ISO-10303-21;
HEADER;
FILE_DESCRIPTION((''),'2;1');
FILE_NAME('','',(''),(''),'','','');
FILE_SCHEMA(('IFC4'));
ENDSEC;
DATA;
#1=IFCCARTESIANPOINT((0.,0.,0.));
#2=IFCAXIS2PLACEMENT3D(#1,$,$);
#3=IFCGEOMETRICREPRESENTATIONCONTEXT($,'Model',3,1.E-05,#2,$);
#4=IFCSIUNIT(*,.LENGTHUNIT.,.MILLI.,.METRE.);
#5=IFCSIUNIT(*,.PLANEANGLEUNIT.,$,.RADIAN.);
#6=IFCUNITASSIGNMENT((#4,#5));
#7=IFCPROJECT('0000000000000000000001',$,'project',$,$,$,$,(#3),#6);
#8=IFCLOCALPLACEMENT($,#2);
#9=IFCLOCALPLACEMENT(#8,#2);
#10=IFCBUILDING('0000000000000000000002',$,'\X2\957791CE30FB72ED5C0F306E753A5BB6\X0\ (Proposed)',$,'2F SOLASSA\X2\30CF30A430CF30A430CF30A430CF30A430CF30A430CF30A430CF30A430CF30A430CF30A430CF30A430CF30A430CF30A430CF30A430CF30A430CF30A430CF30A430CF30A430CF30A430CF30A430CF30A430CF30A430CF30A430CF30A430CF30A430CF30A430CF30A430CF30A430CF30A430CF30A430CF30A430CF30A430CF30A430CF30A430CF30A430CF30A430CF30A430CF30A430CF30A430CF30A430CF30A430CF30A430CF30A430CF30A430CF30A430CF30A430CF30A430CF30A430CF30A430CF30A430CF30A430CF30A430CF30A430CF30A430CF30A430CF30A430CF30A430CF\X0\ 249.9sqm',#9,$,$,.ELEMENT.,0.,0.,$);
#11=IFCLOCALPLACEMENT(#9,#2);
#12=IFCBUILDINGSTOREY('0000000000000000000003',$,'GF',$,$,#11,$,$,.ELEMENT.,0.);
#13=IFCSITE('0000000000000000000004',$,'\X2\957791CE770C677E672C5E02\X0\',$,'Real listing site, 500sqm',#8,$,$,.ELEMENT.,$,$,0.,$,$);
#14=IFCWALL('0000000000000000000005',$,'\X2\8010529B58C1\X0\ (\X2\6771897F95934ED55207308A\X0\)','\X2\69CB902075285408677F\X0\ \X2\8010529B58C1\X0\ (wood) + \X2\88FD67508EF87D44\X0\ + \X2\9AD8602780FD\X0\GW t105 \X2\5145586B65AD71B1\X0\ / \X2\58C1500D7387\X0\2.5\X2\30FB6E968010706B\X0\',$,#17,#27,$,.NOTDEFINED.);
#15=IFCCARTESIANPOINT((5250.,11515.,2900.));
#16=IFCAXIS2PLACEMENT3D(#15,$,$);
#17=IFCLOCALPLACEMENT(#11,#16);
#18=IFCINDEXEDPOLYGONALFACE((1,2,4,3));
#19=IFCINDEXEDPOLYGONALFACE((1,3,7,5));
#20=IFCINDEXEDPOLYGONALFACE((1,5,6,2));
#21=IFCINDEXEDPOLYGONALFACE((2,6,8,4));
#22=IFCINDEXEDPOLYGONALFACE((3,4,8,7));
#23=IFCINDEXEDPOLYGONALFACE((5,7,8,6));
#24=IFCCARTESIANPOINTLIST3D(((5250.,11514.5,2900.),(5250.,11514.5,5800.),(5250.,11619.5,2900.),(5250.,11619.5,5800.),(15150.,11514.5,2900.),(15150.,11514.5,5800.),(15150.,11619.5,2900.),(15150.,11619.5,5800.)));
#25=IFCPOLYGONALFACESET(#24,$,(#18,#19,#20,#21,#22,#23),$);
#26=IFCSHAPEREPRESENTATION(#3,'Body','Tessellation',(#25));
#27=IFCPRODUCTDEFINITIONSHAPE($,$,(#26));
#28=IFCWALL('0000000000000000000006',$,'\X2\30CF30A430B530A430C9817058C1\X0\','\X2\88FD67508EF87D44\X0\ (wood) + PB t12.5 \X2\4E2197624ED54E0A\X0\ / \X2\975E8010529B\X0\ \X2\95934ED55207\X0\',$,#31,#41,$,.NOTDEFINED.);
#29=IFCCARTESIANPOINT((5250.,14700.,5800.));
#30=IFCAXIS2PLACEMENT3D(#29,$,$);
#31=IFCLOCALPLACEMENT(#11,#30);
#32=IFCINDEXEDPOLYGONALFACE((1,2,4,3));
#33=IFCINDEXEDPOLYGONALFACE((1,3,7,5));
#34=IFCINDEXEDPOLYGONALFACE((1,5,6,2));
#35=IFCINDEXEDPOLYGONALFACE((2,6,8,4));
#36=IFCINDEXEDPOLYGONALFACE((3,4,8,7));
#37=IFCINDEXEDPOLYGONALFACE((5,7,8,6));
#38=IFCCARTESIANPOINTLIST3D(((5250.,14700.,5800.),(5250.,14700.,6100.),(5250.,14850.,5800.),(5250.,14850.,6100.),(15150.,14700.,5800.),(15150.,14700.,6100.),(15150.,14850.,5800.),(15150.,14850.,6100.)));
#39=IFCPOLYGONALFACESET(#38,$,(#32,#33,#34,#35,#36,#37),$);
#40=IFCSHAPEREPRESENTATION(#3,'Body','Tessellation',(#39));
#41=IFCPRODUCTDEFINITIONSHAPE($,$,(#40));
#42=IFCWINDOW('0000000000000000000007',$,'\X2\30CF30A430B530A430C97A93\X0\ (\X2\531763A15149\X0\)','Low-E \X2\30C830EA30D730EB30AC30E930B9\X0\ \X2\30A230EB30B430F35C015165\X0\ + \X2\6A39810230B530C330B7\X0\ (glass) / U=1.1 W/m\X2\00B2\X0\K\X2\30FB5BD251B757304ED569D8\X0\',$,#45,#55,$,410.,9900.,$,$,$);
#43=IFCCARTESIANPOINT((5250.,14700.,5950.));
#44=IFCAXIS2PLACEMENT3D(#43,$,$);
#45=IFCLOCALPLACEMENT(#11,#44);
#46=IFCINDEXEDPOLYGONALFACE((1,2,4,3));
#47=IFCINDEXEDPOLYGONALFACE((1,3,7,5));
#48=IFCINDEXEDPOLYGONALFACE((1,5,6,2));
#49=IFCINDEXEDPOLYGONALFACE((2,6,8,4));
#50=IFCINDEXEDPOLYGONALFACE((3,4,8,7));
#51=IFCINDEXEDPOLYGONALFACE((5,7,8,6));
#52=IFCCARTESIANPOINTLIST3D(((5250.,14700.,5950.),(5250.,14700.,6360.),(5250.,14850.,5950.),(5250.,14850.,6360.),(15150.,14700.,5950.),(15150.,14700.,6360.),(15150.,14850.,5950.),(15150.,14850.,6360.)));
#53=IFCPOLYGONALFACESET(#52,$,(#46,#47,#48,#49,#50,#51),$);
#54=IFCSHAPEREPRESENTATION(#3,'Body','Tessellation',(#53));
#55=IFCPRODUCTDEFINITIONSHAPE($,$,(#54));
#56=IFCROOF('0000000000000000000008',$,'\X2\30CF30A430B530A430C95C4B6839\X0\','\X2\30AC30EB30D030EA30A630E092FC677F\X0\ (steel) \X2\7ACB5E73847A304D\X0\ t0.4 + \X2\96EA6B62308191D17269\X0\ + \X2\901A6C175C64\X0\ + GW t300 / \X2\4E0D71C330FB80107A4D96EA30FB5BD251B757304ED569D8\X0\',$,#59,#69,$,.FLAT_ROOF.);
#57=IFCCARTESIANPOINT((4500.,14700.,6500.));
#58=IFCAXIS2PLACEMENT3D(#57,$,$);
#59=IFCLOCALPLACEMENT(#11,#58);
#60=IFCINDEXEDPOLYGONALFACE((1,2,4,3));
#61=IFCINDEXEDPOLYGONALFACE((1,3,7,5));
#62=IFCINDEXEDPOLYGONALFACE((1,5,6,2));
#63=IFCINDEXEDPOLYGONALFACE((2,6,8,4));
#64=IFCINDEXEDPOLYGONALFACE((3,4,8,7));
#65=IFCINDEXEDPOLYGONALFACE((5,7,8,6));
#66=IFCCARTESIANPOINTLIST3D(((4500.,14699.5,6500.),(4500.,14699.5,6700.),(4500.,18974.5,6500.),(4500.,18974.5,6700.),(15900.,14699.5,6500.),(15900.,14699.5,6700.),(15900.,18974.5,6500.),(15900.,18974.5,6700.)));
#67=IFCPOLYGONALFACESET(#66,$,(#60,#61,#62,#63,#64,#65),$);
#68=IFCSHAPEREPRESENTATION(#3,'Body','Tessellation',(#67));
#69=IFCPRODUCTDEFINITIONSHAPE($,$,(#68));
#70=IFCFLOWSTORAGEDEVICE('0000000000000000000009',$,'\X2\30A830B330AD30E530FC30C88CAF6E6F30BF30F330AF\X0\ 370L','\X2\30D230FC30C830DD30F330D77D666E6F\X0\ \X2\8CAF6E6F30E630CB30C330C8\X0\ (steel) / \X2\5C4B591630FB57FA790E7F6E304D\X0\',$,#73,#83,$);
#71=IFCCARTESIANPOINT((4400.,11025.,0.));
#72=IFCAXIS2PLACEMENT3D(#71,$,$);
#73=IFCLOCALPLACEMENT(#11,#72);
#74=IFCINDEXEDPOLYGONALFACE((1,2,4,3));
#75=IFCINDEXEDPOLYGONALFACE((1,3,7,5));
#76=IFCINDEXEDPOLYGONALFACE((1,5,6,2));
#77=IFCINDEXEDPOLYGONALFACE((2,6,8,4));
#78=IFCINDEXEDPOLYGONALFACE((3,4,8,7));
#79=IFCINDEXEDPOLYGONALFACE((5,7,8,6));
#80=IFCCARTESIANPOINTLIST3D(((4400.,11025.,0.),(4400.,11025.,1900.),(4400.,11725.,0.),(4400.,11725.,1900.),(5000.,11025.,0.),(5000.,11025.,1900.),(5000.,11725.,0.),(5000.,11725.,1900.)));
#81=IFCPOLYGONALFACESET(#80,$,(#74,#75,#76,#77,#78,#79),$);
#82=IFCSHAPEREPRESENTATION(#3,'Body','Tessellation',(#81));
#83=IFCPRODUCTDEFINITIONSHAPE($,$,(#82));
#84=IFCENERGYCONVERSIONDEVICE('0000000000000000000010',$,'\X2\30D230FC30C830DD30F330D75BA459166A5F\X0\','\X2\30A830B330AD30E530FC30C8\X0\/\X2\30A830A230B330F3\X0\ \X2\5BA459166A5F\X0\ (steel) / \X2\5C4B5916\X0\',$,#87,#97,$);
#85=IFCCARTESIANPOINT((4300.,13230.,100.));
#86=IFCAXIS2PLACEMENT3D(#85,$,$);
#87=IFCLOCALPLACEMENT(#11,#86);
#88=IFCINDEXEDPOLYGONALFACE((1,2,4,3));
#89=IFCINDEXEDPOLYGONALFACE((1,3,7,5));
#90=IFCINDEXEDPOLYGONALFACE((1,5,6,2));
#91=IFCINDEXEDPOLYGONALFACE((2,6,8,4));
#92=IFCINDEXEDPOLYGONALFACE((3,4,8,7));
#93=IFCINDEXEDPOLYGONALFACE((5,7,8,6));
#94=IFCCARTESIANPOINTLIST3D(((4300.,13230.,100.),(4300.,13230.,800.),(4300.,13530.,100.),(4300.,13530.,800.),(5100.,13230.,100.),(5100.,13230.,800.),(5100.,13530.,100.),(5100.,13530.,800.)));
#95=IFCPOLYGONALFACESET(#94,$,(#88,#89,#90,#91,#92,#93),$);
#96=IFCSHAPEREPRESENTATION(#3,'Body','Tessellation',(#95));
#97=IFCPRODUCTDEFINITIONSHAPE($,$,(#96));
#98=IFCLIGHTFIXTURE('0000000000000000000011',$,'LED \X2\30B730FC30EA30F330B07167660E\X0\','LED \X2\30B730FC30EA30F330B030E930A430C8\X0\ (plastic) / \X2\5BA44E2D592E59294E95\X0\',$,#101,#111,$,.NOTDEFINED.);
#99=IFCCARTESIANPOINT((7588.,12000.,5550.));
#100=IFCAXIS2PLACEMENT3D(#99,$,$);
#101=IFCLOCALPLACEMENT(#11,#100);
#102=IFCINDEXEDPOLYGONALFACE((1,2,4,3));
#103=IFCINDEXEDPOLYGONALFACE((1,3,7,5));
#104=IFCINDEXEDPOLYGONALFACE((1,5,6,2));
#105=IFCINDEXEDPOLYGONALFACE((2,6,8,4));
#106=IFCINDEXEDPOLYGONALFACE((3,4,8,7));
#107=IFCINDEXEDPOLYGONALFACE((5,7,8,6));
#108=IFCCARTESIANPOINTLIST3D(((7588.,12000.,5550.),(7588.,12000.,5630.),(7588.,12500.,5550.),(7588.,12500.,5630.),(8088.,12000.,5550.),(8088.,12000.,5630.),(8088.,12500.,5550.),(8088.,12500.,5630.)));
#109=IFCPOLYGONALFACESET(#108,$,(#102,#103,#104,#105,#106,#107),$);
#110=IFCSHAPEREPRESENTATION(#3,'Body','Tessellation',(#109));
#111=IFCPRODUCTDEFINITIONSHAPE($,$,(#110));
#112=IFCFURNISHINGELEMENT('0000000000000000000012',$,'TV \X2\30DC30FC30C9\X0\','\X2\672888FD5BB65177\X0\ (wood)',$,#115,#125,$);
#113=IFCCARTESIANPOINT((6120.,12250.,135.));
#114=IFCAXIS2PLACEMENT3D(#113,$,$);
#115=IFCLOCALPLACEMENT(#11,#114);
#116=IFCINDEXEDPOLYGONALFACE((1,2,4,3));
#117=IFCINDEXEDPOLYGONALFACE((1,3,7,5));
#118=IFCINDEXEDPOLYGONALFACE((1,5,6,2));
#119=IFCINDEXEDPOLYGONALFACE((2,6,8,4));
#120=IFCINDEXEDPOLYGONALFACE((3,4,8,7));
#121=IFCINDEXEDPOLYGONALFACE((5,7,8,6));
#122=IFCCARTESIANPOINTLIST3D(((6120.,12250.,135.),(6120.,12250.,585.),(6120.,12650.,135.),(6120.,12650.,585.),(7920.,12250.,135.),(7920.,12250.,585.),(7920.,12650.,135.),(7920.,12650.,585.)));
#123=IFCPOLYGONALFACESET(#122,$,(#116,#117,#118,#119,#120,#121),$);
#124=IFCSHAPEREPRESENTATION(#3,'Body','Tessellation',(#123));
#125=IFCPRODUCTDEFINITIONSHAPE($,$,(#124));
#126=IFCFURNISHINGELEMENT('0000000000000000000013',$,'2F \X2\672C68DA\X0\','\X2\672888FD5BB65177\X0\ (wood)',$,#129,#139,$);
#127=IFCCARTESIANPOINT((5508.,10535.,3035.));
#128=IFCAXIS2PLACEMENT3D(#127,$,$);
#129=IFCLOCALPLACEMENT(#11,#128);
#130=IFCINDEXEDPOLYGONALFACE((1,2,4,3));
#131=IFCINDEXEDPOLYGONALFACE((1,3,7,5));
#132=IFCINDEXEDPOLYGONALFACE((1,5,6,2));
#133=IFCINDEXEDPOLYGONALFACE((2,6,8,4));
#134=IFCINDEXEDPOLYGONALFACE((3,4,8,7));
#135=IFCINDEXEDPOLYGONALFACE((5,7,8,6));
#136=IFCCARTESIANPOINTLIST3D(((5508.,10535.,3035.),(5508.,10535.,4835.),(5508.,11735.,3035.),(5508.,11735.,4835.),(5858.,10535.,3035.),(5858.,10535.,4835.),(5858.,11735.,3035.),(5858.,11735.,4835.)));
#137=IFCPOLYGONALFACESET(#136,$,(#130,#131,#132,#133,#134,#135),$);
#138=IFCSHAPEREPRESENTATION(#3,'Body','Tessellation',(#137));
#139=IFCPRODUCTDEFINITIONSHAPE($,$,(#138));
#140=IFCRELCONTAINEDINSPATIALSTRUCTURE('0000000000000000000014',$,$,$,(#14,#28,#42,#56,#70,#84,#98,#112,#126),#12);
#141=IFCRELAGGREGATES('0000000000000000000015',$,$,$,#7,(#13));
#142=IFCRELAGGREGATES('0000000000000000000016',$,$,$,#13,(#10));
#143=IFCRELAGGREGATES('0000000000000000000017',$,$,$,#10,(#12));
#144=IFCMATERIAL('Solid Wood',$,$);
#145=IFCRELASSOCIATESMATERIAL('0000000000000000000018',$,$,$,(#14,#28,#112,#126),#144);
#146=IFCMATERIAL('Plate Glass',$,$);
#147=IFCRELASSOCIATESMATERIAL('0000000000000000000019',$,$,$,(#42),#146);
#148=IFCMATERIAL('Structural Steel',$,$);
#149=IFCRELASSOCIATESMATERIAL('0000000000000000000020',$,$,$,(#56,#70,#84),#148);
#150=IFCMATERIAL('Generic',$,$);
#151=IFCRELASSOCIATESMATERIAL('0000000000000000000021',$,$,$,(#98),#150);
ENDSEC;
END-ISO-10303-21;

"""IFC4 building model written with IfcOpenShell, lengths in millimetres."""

from ifc_helpers import new_model, si_unit, frame, frame_2d, origin, place, context, project, spatial, rectangle, extrude, material, element, fill, save


model = new_model("IFC4")

# Units and contexts
model_context = context("Model", 3, precision=1e-05, world=origin())
ifc_project = project(units=[si_unit("LENGTHUNIT", "METRE", prefix="MILLI"), si_unit("PLANEANGLEUNIT", "RADIAN")], contexts=[model_context])

# Site, building, storey
site_placement = place(None, origin())
site = spatial("IfcSite", under=ifc_project, at=site_placement, Name="長野県松本市", ObjectType="Real listing site, 500sqm", CompositionType="ELEMENT", RefElevation=0.0)
building_placement = place(site_placement, origin())
building = spatial("IfcBuilding", under=site, at=building_placement, Name="長野・狭小の町家 (Proposed)", ObjectType="2F SOLASSAハイハイハイハイハイハイハイハイハイハイハイハイハイハイハイハイハイハイハイハイハイハイハイハイハイハイハイハイハイハイハイハイハイハイハイハイハイハイハイハイハイハイハイハイハイハイハイハイハイハイハイハイハイハイハイハイハ 249.9sqm", CompositionType="ELEMENT", ElevationOfRefHeight=0.0, ElevationOfTerrain=0.0)
storey_placement = place(building_placement, origin())
storey = spatial("IfcBuildingStorey", under=building, at=storey_placement, Name="GF", CompositionType="ELEMENT", Elevation=0.0)

# Shared definitions
ifc_material_1 = material(Name="Solid Wood")

# Wall
wall_1_placement = place(storey_placement, frame((5250.0, 11515.0, 2900.0)))
element("IfcWall", 1, at=wall_1_placement, inside=storey, material=ifc_material_1, Name="耐力壁 (東西間仕切り)", Description="構造用合板 耐力壁 (wood) + 製材軸組 + 高性能GW t105 充填断熱 / 壁倍率2.5・準耐火", PredefinedType="NOTDEFINED", context=model_context, shape_type="SweptSolid", body=[
    extrude(rectangle(XDim=9900.0, YDim=105.0, at=frame_2d((4950.0, 52.0))), frame((5250.0, 11515.0, 2900.0)), (0.0, 0.0, 1.0), 2900.0),
])

# Wall, opening, window
wall_2_placement = place(storey_placement, frame((5250.0, 14700.0, 5800.0)))
wall_2 = element("IfcWall", 2, at=wall_2_placement, inside=storey, material=ifc_material_1, Name="ハイサイド腰壁", Description="製材軸組 (wood) + PB t12.5 両面仕上 / 非耐力 間仕切", PredefinedType="NOTDEFINED", context=model_context, shape_type="SweptSolid", body=[
    extrude(rectangle(XDim=9900.0, YDim=150.0, at=frame_2d((4950.0, 75.0))), frame((5250.0, 14700.0, 5800.0)), (0.0, 0.0, 1.0), 700.0),
])
opening_1_placement = place(storey_placement, frame((5250.0, 14700.0, 5950.0)))
opening_1 = element("IfcOpeningElement", 3, at=opening_1_placement, cuts=wall_2, PredefinedType="NOTDEFINED", context=model_context, shape_type="SweptSolid", body=[
    extrude(rectangle(XDim=9900.0, YDim=150.0, at=frame_2d((4950.0, 75.0))), frame((5250.0, 14700.0, 5950.0)), (0.0, 0.0, 1.0), 410.0),
])
ifc_material_2 = material(Name="Plate Glass")
window_placement = place(storey_placement, frame((5250.0, 14700.0, 5950.0)))
window = element("IfcWindow", 4, at=window_placement, inside=storey, material=ifc_material_2, Name="ハイサイド窓 (北採光)", Description="Low-E トリプルガラス アルゴン封入 + 樹脂サッシ (glass) / U=1.1 W/m²K・寒冷地仕様", OverallHeight=410.0, OverallWidth=9900.0, context=model_context, shape_type="SweptSolid", body=[
    extrude(rectangle(XDim=9900.0, YDim=150.0, at=frame_2d((4950.0, 75.0))), frame((5250.0, 14700.0, 5950.0)), (0.0, 0.0, 1.0), 410.0),
])
fill(opening_1, window)

# Roof
ifc_material_3 = material(Name="Structural Steel")
roof_placement = place(storey_placement, frame((4500.0, 14700.0, 6500.0)))
element("IfcRoof", 5, at=roof_placement, inside=storey, material=ifc_material_3, Name="ハイサイド屋根", Description="ガルバリウム鋼板 (steel) 立平葺き t0.4 + 雪止め金物 + 通気層 + GW t300 / 不燃・耐積雪・寒冷地仕様", PredefinedType="FLAT_ROOF", context=model_context, shape_type="SweptSolid", body=[
    extrude(rectangle(XDim=11400.0, YDim=4275.0, at=frame_2d((5700.0, 2137.0))), frame((4500.0, 14700.0, 6500.0)), (0.0, 0.0, 1.0), 200.0),
])

# Flow storage device
flow_storage_device_placement = place(storey_placement, frame((4400.0, 11025.0, 0.0)))
element("IfcFlowStorageDevice", 6, at=flow_storage_device_placement, inside=storey, material=ifc_material_3, Name="エコキュート貯湯タンク 370L", Description="ヒートポンプ給湯 貯湯ユニット (steel) / 屋外・基礎置き", context=model_context, shape_type="SweptSolid", body=[
    extrude(rectangle(XDim=600.0, YDim=700.0, at=frame_2d((300.0, 350.0))), frame((4400.0, 11025.0, 0.0)), (0.0, 0.0, 1.0), 1900.0),
])

# Energy conversion device
energy_conversion_device_placement = place(storey_placement, frame((4300.0, 13230.0, 100.0)))
element("IfcEnergyConversionDevice", 7, at=energy_conversion_device_placement, inside=storey, material=ifc_material_3, Name="ヒートポンプ室外機", Description="エコキュート/エアコン 室外機 (steel) / 屋外", context=model_context, shape_type="SweptSolid", body=[
    extrude(rectangle(XDim=800.0, YDim=300.0, at=frame_2d((400.0, 150.0))), frame((4300.0, 13230.0, 100.0)), (0.0, 0.0, 1.0), 700.0),
])

# Light fixture
ifc_material_4 = material(Name="Generic")
light_fixture_placement = place(storey_placement, frame((7588.0, 12000.0, 5550.0)))
element("IfcLightFixture", 8, at=light_fixture_placement, inside=storey, material=ifc_material_4, Name="LED シーリング照明", Description="LED シーリングライト (plastic) / 室中央天井", PredefinedType="NOTDEFINED", context=model_context, shape_type="SweptSolid", body=[
    extrude(rectangle(XDim=500.0, YDim=500.0, at=frame_2d((250.0, 250.0))), frame((7588.0, 12000.0, 5550.0)), (0.0, 0.0, 1.0), 80.0),
])

# Furnishing elements
furnishing_1_placement = place(storey_placement, frame((6120.0, 12250.0, 135.0)))
element("IfcFurnishingElement", 9, at=furnishing_1_placement, inside=storey, material=ifc_material_1, Name="TV ボード", Description="木製家具 (wood)", context=model_context, shape_type="SweptSolid", body=[
    extrude(rectangle(XDim=1800.0, YDim=400.0, at=frame_2d((900.0, 200.0))), frame((6120.0, 12250.0, 135.0)), (0.0, 0.0, 1.0), 450.0),
])
furnishing_2_placement = place(storey_placement, frame((5508.0, 10535.0, 3035.0)))
element("IfcFurnishingElement", 10, at=furnishing_2_placement, inside=storey, material=ifc_material_1, Name="2F 本棚", Description="木製家具 (wood)", context=model_context, shape_type="SweptSolid", body=[
    extrude(rectangle(XDim=350.0, YDim=1200.0, at=frame_2d((175.0, 600.0))), frame((5508.0, 10535.0, 3035.0)), (0.0, 0.0, 1.0), 1800.0),
])

save(model, "model.ifc")
